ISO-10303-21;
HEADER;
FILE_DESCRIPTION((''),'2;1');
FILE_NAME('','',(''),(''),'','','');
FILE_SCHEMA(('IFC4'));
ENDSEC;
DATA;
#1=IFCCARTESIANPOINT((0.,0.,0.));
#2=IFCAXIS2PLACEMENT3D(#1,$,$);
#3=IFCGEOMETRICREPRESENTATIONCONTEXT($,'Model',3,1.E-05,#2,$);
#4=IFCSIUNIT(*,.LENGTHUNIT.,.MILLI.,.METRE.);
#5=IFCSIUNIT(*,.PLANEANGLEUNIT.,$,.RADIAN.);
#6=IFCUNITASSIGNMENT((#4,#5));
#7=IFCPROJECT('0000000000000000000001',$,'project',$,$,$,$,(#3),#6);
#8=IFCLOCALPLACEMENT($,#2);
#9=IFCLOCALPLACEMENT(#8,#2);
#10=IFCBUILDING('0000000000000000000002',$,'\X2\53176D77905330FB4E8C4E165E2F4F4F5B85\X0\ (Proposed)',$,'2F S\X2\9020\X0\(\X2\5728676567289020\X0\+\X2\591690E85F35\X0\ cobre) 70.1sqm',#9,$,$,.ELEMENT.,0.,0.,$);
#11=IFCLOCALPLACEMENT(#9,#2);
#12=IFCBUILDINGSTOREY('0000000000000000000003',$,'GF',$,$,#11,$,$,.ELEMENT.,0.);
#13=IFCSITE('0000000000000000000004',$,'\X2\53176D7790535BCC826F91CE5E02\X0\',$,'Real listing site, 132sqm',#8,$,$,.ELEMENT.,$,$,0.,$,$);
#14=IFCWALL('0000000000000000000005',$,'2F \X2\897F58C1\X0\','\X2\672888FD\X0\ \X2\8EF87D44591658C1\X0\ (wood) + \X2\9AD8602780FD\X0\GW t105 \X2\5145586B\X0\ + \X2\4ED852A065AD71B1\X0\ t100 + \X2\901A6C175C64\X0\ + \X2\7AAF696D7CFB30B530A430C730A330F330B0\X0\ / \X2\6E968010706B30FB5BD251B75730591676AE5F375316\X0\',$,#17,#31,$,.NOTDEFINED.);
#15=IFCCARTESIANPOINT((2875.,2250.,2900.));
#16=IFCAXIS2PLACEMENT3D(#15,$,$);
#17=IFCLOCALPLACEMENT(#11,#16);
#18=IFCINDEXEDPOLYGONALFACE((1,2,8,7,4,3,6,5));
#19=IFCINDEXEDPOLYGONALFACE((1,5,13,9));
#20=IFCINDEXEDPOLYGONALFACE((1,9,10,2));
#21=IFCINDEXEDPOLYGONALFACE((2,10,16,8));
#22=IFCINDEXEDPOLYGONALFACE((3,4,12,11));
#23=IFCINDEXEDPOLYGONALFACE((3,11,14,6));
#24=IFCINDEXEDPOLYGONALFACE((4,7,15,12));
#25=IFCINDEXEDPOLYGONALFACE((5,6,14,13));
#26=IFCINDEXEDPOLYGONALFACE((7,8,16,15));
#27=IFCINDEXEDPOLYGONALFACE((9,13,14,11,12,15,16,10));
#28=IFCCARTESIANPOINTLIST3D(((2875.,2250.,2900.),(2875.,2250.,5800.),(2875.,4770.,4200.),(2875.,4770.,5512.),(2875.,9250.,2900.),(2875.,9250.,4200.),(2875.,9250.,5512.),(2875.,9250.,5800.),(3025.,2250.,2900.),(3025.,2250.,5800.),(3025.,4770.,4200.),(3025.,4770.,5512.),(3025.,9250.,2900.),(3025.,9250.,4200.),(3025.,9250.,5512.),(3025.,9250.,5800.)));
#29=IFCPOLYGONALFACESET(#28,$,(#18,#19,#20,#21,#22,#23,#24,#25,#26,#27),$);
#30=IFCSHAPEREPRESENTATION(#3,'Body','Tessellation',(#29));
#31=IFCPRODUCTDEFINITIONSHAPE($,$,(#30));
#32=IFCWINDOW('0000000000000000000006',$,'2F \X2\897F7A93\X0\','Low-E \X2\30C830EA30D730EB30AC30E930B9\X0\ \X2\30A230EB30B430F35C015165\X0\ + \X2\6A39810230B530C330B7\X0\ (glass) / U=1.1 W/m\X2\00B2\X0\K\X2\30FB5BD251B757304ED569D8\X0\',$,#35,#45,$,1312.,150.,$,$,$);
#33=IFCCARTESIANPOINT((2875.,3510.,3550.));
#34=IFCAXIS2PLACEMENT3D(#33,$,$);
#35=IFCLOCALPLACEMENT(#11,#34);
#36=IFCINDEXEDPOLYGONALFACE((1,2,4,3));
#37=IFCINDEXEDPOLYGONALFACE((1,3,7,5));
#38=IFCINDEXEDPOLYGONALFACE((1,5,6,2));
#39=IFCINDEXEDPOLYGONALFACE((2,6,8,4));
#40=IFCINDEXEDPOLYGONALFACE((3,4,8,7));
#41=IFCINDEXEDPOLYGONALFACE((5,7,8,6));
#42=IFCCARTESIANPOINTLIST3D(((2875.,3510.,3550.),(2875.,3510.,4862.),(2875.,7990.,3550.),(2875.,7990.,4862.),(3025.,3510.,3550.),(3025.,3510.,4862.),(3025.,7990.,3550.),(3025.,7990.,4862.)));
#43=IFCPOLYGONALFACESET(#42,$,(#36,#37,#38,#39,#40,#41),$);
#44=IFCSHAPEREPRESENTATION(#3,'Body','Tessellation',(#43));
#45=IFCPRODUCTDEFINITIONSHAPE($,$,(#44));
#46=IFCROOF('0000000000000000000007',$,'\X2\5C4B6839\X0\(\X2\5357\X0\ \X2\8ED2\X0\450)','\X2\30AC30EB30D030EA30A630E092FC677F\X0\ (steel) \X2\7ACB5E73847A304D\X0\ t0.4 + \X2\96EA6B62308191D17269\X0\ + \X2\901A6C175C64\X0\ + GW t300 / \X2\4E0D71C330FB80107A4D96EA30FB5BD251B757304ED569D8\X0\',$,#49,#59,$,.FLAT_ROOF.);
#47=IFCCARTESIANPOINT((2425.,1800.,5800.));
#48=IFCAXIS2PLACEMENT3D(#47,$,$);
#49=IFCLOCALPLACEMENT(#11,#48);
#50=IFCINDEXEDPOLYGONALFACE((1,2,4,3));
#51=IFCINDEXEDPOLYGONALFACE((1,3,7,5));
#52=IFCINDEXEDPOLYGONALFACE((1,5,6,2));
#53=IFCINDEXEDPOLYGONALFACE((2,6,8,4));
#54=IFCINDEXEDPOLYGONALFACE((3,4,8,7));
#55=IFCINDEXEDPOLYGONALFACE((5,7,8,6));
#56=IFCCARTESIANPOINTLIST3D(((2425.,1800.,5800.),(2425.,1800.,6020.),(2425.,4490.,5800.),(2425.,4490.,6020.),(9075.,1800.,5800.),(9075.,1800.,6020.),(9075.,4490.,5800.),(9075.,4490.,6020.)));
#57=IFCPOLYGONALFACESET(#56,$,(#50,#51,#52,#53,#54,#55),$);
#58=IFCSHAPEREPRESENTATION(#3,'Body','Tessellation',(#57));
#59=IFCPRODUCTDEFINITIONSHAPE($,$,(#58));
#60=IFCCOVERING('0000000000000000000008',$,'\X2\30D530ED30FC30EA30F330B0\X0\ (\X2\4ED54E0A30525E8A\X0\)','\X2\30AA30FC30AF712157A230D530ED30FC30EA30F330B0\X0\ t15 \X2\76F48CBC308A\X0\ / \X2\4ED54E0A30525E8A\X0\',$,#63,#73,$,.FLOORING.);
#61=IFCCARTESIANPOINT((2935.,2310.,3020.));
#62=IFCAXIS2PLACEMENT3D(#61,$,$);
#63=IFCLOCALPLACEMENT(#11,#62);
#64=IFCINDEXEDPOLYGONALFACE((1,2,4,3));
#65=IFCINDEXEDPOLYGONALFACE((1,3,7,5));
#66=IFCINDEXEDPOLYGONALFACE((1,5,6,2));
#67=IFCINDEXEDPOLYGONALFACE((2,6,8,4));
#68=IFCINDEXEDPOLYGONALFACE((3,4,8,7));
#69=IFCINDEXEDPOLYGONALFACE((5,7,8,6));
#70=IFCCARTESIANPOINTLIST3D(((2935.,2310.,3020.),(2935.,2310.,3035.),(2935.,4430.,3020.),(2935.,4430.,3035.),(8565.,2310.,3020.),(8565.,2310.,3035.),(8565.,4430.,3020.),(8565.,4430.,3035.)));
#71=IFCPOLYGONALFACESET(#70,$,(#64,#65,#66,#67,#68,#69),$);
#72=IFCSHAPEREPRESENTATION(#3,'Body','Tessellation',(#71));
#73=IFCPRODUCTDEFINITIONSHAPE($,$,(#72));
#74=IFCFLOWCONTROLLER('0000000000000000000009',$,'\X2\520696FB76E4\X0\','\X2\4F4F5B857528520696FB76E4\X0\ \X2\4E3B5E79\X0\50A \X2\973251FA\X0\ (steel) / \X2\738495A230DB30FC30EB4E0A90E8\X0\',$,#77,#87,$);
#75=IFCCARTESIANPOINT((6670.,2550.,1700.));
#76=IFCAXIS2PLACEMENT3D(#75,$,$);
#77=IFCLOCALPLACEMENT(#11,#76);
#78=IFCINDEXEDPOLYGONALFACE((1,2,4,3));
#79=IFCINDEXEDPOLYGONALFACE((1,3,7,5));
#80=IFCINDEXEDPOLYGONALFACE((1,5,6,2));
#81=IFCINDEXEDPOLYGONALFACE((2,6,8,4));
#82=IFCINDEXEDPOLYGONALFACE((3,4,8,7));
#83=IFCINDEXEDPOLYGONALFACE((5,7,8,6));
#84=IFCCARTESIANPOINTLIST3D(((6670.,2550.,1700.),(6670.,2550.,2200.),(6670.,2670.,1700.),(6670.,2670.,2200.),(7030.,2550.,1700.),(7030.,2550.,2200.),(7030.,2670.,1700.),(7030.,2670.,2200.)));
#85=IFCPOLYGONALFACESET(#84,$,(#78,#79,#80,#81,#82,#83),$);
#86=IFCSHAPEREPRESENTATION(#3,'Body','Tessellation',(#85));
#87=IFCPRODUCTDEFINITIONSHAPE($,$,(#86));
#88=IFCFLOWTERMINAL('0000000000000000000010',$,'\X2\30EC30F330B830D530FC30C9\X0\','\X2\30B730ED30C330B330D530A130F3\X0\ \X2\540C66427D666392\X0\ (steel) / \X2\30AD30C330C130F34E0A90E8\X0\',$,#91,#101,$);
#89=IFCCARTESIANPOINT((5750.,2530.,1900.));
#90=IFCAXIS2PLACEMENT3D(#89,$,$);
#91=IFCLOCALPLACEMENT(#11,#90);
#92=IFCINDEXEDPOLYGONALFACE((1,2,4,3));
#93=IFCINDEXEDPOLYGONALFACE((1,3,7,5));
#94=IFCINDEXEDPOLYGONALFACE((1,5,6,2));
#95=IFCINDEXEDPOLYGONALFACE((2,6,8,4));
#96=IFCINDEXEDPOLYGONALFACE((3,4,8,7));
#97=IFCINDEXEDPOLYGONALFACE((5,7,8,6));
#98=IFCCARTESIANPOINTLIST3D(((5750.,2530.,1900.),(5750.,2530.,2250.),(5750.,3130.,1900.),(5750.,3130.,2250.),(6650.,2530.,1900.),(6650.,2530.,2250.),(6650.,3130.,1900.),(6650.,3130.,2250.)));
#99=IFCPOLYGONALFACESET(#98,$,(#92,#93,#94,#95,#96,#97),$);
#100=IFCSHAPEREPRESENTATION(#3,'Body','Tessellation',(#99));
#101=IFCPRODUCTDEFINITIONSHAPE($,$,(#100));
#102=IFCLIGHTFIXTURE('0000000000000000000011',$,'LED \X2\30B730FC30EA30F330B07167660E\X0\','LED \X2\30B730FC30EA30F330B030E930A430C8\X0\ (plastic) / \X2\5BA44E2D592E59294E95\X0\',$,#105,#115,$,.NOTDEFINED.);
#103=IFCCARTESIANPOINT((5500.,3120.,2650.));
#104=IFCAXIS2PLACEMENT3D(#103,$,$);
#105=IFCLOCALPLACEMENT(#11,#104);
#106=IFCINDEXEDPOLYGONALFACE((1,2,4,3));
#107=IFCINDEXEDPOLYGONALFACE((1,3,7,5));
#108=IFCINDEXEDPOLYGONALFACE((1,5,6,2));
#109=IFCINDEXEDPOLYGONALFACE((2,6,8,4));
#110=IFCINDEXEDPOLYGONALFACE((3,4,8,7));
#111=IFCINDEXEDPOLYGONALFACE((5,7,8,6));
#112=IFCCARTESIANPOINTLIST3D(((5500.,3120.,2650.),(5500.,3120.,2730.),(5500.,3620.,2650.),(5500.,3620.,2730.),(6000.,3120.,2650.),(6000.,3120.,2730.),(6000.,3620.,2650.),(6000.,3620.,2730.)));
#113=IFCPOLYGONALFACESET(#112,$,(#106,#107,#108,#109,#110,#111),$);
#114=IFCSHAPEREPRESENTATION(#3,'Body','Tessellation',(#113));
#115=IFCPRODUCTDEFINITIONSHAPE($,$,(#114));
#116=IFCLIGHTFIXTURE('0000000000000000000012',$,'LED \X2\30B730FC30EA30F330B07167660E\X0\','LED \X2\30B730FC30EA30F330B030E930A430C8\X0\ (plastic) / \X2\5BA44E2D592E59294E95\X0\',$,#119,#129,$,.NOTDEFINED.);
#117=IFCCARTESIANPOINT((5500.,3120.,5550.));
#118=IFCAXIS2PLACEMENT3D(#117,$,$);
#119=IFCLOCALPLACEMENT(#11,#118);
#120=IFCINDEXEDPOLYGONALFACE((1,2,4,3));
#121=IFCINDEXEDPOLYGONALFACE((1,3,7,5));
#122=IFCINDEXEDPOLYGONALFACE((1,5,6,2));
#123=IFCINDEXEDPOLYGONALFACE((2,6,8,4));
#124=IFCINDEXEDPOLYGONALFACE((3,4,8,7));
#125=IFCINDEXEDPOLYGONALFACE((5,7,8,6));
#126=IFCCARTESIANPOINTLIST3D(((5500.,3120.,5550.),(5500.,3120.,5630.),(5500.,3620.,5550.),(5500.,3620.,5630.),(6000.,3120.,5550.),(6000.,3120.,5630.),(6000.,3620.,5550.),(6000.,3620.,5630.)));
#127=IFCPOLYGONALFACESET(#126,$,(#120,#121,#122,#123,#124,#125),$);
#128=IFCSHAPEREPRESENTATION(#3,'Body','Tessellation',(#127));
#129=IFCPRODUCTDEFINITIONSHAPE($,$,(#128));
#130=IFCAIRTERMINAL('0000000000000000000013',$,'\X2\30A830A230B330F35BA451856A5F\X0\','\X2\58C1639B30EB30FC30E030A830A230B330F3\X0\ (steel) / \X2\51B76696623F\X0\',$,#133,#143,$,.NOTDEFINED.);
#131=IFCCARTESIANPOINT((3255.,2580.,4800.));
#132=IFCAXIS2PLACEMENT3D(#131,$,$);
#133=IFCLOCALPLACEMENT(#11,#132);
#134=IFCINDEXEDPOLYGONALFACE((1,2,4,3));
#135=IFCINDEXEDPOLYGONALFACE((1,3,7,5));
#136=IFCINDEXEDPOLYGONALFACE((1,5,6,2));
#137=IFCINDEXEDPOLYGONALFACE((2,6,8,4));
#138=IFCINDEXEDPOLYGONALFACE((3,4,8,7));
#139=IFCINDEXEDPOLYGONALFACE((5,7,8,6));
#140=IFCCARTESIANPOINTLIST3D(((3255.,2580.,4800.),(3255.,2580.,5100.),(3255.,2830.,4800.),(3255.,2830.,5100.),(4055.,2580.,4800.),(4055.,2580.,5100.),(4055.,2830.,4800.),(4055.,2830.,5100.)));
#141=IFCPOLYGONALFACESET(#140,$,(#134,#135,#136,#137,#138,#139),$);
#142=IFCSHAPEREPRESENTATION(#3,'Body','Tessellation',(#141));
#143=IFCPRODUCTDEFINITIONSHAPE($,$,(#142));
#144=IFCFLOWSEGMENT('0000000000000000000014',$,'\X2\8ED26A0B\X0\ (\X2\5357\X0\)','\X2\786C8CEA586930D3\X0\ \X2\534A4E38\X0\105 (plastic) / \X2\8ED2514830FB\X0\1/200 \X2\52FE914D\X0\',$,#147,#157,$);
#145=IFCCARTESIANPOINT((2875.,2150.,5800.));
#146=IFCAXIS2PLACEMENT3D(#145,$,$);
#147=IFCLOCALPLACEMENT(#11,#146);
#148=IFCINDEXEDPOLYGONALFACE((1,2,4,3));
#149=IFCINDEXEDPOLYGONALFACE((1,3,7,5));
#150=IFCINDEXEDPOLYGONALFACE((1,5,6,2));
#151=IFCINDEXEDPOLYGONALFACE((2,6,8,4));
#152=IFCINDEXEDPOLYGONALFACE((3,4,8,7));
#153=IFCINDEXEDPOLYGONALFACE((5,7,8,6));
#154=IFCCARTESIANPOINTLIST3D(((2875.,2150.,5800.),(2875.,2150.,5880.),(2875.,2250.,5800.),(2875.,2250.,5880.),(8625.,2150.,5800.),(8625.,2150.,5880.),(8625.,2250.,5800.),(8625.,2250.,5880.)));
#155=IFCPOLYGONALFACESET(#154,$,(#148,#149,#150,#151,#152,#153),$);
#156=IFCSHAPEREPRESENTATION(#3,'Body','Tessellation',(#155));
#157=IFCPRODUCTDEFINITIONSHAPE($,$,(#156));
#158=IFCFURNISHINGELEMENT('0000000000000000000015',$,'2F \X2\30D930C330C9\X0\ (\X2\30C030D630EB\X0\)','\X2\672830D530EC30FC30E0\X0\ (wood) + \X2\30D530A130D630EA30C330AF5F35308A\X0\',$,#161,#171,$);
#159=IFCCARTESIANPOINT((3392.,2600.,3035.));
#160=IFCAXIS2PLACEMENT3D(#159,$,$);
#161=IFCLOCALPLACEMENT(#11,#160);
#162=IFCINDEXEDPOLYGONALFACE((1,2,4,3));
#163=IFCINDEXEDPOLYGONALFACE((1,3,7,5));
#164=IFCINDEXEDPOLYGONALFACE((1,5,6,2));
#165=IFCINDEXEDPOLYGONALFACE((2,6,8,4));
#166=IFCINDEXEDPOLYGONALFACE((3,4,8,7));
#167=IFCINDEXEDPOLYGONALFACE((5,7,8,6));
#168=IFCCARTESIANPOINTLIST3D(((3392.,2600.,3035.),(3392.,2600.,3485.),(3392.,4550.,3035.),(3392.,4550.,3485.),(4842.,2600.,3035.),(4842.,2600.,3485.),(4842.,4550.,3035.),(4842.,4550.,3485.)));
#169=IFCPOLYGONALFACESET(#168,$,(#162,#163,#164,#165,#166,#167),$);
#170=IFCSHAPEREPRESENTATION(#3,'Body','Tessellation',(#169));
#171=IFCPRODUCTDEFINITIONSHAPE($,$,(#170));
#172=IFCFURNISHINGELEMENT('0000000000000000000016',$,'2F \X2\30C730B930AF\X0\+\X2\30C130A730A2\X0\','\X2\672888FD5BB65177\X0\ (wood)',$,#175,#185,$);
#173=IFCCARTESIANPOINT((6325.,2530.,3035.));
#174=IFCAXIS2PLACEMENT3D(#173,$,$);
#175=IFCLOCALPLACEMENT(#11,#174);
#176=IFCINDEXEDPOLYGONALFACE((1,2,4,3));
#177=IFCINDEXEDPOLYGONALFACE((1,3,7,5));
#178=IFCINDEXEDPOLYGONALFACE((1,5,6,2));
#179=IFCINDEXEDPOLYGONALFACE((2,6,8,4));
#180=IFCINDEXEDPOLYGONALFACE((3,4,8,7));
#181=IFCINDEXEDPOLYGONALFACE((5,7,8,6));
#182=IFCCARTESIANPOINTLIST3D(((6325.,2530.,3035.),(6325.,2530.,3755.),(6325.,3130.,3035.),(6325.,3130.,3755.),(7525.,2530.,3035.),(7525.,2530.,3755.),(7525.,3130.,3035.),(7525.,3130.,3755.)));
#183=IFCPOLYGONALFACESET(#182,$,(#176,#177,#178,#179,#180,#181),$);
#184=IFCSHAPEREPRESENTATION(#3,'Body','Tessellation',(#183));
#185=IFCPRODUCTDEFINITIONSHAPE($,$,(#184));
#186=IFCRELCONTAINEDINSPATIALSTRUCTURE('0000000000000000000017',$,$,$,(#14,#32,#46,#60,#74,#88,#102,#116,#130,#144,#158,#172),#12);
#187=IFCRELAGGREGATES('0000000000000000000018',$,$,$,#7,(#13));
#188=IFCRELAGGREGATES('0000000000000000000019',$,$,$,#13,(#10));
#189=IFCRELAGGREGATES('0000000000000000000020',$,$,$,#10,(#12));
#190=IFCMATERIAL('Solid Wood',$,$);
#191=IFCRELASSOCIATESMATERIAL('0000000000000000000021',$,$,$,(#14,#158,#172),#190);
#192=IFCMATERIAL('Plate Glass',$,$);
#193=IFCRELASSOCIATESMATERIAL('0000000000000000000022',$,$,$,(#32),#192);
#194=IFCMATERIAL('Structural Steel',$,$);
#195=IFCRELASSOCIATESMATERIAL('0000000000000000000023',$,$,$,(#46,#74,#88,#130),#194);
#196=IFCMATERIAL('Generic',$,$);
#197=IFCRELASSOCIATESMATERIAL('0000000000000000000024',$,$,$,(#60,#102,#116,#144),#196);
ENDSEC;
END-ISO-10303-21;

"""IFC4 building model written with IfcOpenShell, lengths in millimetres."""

from ifc_helpers import new_model, si_unit, frame, frame_2d, origin, place, context, project, spatial, rectangle, extrude, material, element, fill, save


model = new_model("IFC4")

# Units and contexts
model_context = context("Model", 3, precision=1e-05, world=origin())
ifc_project = project(units=[si_unit("LENGTHUNIT", "METRE", prefix="MILLI"), si_unit("PLANEANGLEUNIT", "RADIAN")], contexts=[model_context])

# Site, building, storey
site_placement = place(None, origin())
site = spatial("IfcSite", under=ifc_project, at=site_placement, Name="北海道富良野市", ObjectType="Real listing site, 132sqm", CompositionType="ELEMENT", RefElevation=0.0)
building_placement = place(site_placement, origin())
building = spatial("IfcBuilding", under=site, at=building_placement, Name="北海道・二世帯住宅 (Proposed)", ObjectType="2F S造(在来木造+外部張 cobre) 70.1sqm", CompositionType="ELEMENT", ElevationOfRefHeight=0.0, ElevationOfTerrain=0.0)
storey_placement = place(building_placement, origin())
storey = spatial("IfcBuildingStorey", under=building, at=storey_placement, Name="GF", CompositionType="ELEMENT", Elevation=0.0)

# Shared definitions
ifc_material_1 = material(Name="Solid Wood")

# Wall, opening, window
ifc_material_2 = material(Name="Plate Glass")
wall_1_placement = place(storey_placement, frame((2875.0, 2250.0, 2900.0)))
wall_1 = element("IfcWall", 1, at=wall_1_placement, inside=storey, material=ifc_material_1, Name="2F 西壁", Description="木製 軸組外壁 (wood) + 高性能GW t105 充填 + 付加断熱 t100 + 通気層 + 窯業系サイディング / 準耐火・寒冷地外皮強化", PredefinedType="NOTDEFINED", context=model_context, shape_type="SweptSolid", body=[
    extrude(rectangle(XDim=150.0, YDim=7000.0, at=frame_2d((75.0, 3500.0))), frame((2875.0, 2250.0, 2900.0)), (0.0, 0.0, 1.0), 2900.0),
])
opening_1_placement = place(storey_placement, frame((2875.0, 3510.0, 3550.0)))
opening_1 = element("IfcOpeningElement", 2, at=opening_1_placement, cuts=wall_1, PredefinedType="NOTDEFINED", context=model_context, shape_type="SweptSolid", body=[
    extrude(rectangle(XDim=150.0, YDim=4480.0, at=frame_2d((75.0, 2240.0))), frame((2875.0, 3510.0, 3550.0)), (0.0, 0.0, 1.0), 1312.0),
])
window_1_placement = place(storey_placement, frame((2875.0, 3510.0, 3550.0)))
window_1 = element("IfcWindow", 3, at=window_1_placement, inside=storey, material=ifc_material_2, Name="2F 西窓", Description="Low-E トリプルガラス アルゴン封入 + 樹脂サッシ (glass) / U=1.1 W/m²K・寒冷地仕様", OverallHeight=1312.0, OverallWidth=150.0, context=model_context, shape_type="SweptSolid", body=[
    extrude(rectangle(XDim=150.0, YDim=4480.0, at=frame_2d((75.0, 2240.0))), frame((2875.0, 3510.0, 3550.0)), (0.0, 0.0, 1.0), 1312.0),
])
fill(opening_1, window_1)

# Roof
ifc_material_3 = material(Name="Structural Steel")
for number, where, name in (
    (4, (2425.0, 1800.0, 5800.0), "屋根(南 軒450)"),
):
    element("IfcRoof", number, at=place(storey_placement, frame(where)), inside=storey, material=ifc_material_3, Name=name, Description="ガルバリウム鋼板 (steel) 立平葺き t0.4 + 雪止め金物 + 通気層 + GW t300 / 不燃・耐積雪・寒冷地仕様", PredefinedType="FLAT_ROOF", context=model_context, shape_type="SweptSolid", body=[
        extrude(rectangle(XDim=6650.0, YDim=2690.0, at=frame_2d((3325.0, 1345.0))), frame((2425.0, 1800.0, 5800.0)), (0.0, 0.0, 1.0), 220.0),
    ])

# Covering
ifc_material_4 = material(Name="Generic")
covering_placement = place(storey_placement, frame((2935.0, 2310.0, 3020.0)))
element("IfcCovering", 5, at=covering_placement, inside=storey, material=ifc_material_4, Name="フローリング (仕上げ床)", Description="オーク無垢フローリング t15 直貼り / 仕上げ床", PredefinedType="FLOORING", context=model_context, shape_type="SweptSolid", body=[
    extrude(rectangle(XDim=5630.0, YDim=2120.0, at=frame_2d((2815.0, 1060.0))), frame((2935.0, 2310.0, 3020.0)), (0.0, 0.0, 1.0), 15.0),
])

# Flow controller
flow_controller_placement = place(storey_placement, frame((6670.0, 2550.0, 1700.0)))
element("IfcFlowController", 6, at=flow_controller_placement, inside=storey, material=ifc_material_3, Name="分電盤", Description="住宅用分電盤 主幹50A 露出 (steel) / 玄関ホール上部", context=model_context, shape_type="SweptSolid", body=[
    extrude(rectangle(XDim=360.0, YDim=120.0, at=frame_2d((180.0, 60.0))), frame((6670.0, 2550.0, 1700.0)), (0.0, 0.0, 1.0), 500.0),
])

# Flow terminal
flow_terminal_placement = place(storey_placement, frame((5750.0, 2530.0, 1900.0)))
element("IfcFlowTerminal", 7, at=flow_terminal_placement, inside=storey, material=ifc_material_3, Name="レンジフード", Description="シロッコファン 同時給排 (steel) / キッチン上部", context=model_context, shape_type="SweptSolid", body=[
    extrude(rectangle(XDim=900.0, YDim=600.0, at=frame_2d((450.0, 300.0))), frame((5750.0, 2530.0, 1900.0)), (0.0, 0.0, 1.0), 350.0),
])

# Light fixtures
light_fixture_1_placement = place(storey_placement, frame((5500.0, 3120.0, 2650.0)))
element("IfcLightFixture", 8, at=light_fixture_1_placement, inside=storey, material=ifc_material_4, Name="LED シーリング照明", Description="LED シーリングライト (plastic) / 室中央天井", PredefinedType="NOTDEFINED", context=model_context, shape_type="SweptSolid", body=[
    extrude(rectangle(XDim=500.0, YDim=500.0, at=frame_2d((250.0, 250.0))), frame((5500.0, 3120.0, 2650.0)), (0.0, 0.0, 1.0), 80.0),
])
light_fixture_2_placement = place(storey_placement, frame((5500.0, 3120.0, 5550.0)))
element("IfcLightFixture", 9, at=light_fixture_2_placement, inside=storey, material=ifc_material_4, Name="LED シーリング照明", Description="LED シーリングライト (plastic) / 室中央天井", PredefinedType="NOTDEFINED", context=model_context, shape_type="SweptSolid", body=[
    extrude(rectangle(XDim=500.0, YDim=500.0, at=frame_2d((250.0, 250.0))), frame((5500.0, 3120.0, 5550.0)), (0.0, 0.0, 1.0), 80.0),
])

# Air terminal
air_terminal_placement = place(storey_placement, frame((3255.0, 2580.0, 4800.0)))
element("IfcAirTerminal", 10, at=air_terminal_placement, inside=storey, material=ifc_material_3, Name="エアコン室内機", Description="壁掛ルームエアコン (steel) / 冷暖房", PredefinedType="NOTDEFINED", context=model_context, shape_type="SweptSolid", body=[
    extrude(rectangle(XDim=800.0, YDim=250.0, at=frame_2d((400.0, 125.0))), frame((3255.0, 2580.0, 4800.0)), (0.0, 0.0, 1.0), 300.0),
])

# Flow segment
flow_segment_placement = place(storey_placement, frame((2875.0, 2150.0, 5800.0)))
element("IfcFlowSegment", 11, at=flow_segment_placement, inside=storey, material=ifc_material_4, Name="軒樋 (南)", Description="硬質塩ビ 半丸105 (plastic) / 軒先・1/200 勾配", context=model_context, shape_type="SweptSolid", body=[
    extrude(rectangle(XDim=5750.0, YDim=100.0, at=frame_2d((2875.0, 50.0))), frame((2875.0, 2150.0, 5800.0)), (0.0, 0.0, 1.0), 80.0),
])

# Furnishing elements
furnishing_1_placement = place(storey_placement, frame((3392.0, 2600.0, 3035.0)))
element("IfcFurnishingElement", 12, at=furnishing_1_placement, inside=storey, material=ifc_material_1, Name="2F ベッド (ダブル)", Description="木フレーム (wood) + ファブリック張り", context=model_context, shape_type="SweptSolid", body=[
    extrude(rectangle(XDim=1450.0, YDim=1950.0, at=frame_2d((725.0, 975.0))), frame((3392.0, 2600.0, 3035.0)), (0.0, 0.0, 1.0), 450.0),
])
furnishing_2_placement = place(storey_placement, frame((6325.0, 2530.0, 3035.0)))
element("IfcFurnishingElement", 13, at=furnishing_2_placement, inside=storey, material=ifc_material_1, Name="2F デスク+チェア", Description="木製家具 (wood)", context=model_context, shape_type="SweptSolid", body=[
    extrude(rectangle(XDim=1200.0, YDim=600.0, at=frame_2d((600.0, 300.0))), frame((6325.0, 2530.0, 3035.0)), (0.0, 0.0, 1.0), 720.0),
])

save(model, "model.ifc")
